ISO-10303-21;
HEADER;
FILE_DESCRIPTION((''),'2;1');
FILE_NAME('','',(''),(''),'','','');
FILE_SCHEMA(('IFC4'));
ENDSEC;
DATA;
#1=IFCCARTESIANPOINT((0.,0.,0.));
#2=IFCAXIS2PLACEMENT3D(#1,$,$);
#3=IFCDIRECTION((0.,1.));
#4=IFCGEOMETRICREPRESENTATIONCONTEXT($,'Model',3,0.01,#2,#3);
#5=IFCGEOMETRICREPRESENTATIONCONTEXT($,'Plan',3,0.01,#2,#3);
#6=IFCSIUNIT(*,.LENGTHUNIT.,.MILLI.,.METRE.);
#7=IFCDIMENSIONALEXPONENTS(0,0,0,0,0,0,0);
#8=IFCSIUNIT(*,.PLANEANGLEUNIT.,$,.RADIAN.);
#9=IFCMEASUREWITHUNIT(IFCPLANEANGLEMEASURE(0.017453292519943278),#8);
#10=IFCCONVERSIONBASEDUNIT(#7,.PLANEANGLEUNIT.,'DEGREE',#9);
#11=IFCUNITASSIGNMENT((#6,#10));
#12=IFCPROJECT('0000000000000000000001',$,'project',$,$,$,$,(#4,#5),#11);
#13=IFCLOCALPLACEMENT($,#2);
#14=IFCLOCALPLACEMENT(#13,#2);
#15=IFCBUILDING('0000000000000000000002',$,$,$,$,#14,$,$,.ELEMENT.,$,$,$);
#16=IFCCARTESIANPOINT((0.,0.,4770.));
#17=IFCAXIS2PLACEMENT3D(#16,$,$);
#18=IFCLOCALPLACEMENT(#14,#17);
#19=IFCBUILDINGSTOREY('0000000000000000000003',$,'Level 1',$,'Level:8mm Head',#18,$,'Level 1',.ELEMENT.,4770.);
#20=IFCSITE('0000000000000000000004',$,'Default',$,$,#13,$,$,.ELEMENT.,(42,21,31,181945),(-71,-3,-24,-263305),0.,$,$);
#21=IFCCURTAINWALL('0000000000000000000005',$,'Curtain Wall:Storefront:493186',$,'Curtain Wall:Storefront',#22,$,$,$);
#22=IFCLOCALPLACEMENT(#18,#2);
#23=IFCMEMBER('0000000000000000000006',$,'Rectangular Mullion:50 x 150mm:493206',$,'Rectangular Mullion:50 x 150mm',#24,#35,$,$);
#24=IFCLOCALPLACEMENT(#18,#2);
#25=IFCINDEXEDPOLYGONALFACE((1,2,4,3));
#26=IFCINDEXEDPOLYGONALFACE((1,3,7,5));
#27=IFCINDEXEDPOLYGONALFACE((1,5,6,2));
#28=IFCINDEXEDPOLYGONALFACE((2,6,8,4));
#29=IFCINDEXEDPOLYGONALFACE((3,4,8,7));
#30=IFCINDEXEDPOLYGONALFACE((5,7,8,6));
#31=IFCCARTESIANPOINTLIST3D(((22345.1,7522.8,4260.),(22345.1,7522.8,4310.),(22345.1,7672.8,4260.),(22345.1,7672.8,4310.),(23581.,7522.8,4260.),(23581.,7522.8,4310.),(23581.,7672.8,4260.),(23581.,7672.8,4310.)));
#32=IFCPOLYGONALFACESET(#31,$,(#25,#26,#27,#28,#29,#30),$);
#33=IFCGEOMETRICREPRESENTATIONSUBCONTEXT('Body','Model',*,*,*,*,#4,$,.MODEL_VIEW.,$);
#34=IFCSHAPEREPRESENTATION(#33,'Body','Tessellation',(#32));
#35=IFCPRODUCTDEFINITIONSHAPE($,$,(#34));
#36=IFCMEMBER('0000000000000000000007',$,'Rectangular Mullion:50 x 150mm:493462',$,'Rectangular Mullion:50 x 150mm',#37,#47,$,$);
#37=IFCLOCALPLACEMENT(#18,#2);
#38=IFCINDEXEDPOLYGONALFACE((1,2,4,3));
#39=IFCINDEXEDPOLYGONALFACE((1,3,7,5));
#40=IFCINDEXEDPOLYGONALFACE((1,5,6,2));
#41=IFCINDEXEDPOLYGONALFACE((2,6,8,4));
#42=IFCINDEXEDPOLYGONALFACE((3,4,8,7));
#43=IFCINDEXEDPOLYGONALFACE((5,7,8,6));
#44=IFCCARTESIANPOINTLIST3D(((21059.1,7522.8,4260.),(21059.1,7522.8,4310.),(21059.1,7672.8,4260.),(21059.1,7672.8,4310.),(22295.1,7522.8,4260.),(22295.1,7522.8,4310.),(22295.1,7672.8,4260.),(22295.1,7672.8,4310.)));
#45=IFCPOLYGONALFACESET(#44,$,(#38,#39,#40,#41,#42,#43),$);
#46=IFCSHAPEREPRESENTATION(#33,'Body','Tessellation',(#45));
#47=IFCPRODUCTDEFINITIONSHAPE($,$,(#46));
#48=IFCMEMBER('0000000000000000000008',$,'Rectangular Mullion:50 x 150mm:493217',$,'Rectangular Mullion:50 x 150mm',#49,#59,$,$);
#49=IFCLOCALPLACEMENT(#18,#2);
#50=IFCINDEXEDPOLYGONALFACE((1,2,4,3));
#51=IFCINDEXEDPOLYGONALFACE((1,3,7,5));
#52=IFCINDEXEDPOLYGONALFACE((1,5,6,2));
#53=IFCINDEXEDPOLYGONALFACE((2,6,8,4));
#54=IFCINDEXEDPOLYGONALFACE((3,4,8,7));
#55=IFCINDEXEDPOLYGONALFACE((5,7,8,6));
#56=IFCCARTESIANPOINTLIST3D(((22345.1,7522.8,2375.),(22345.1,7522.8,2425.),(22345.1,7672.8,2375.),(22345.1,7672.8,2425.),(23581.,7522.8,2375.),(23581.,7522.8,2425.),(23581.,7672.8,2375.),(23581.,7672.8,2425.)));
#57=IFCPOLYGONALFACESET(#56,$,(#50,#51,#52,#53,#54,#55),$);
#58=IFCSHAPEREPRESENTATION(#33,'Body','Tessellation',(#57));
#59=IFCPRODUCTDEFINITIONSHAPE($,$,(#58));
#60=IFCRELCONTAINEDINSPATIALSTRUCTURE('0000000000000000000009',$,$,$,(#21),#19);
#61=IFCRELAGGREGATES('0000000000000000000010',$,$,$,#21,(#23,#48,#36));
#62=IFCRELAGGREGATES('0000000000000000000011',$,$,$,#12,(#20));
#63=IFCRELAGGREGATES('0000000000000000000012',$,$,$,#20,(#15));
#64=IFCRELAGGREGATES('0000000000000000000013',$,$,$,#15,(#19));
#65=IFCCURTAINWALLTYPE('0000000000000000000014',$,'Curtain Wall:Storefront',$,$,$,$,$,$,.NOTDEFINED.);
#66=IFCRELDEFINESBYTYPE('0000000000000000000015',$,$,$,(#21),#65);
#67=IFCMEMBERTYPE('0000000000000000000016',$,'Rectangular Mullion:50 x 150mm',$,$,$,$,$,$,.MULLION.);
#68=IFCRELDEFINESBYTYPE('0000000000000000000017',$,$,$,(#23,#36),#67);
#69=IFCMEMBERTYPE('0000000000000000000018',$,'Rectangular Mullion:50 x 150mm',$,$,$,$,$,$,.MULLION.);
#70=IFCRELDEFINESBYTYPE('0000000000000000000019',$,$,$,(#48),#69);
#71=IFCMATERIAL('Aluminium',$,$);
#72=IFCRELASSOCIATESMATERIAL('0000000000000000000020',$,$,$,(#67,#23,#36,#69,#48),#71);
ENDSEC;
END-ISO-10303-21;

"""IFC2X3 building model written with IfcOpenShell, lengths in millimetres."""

from ifc_helpers import new_model, entity, si_unit, converted_unit, direction, frame, origin, origin_2d_with_axis, place, context, subcontext, project, spatial, rectangle, extrude, source, transform, mapped, material, type_object, type_shapes, element, aggregate, save


model = new_model("IFC2X3")

# Units and contexts
model_context = context("Model", 3, precision=0.01, world=origin(), true_north=direction((0.0, 1.0)))
plan_context = context("Plan", 3, precision=0.01, world=origin(), true_north=direction((0.0, 1.0)))
body_context = subcontext(model_context, "Body", "Model", "MODEL_VIEW")
ifc_project = project(units=[si_unit("LENGTHUNIT", "METRE", prefix="MILLI"), converted_unit("PLANEANGLEUNIT", "DEGREE", entity("IfcPlaneAngleMeasure", 0.017453292519943278), si_unit("PLANEANGLEUNIT", "RADIAN"), dimensions=[0, 0, 0, 0, 0, 0, 0])], contexts=[model_context, plan_context])

# Site, building, storey
site_placement = place(None, origin())
site = spatial("IfcSite", under=ifc_project, at=site_placement, Name="Default", CompositionType="ELEMENT", RefLatitude=(42, 21, 31, 181945), RefLongitude=(-71, -3, -24, -263305), RefElevation=0.0)
building_placement = place(site_placement, origin())
building = spatial("IfcBuilding", under=site, at=building_placement, CompositionType="ELEMENT")
storey_placement = place(building_placement, frame((0.0, 0.0, 4770.0)))
storey = spatial("IfcBuildingStorey", under=building, at=storey_placement, Name="Level 1", ObjectType="Level:8mm Head", LongName="Level 1", CompositionType="ELEMENT", Elevation=4770.0)

# Shared definitions
curtain_wall_type = type_object("IfcCurtainWallType", Name="Curtain Wall:Storefront", PredefinedType="NOTDEFINED")
ifc_material_1 = material(Name="Aluminium")

# Curtain wall
curtain_wall_1_placement = place(storey_placement, frame((0.0, 0.0, -4770.0)))
curtain_wall_1 = element("IfcCurtainWall", 1, at=curtain_wall_1_placement, inside=storey, type_object=curtain_wall_type, Name="Curtain Wall:Storefront:493186", ObjectType="Curtain Wall:Storefront")

# Members
member_type_1 = type_object("IfcMemberType", Name="Rectangular Mullion:50 x 150mm", PredefinedType="MULLION", material=ifc_material_1)
shared_shape_1 = source(origin(), body_context, "Body", "SweptSolid", [
    extrude(rectangle(XDim=50.0, YDim=150.0, at=origin_2d_with_axis()), frame((-25.0, 0.0, -1236.0), z_axis=(0.0, 0.0, 1.0), x_axis=(-1.0, 0.0, 0.0)), (0.0, 0.0, 1.0), 1236.0),
])
type_shapes(member_type_1, [shared_shape_1])
member_1_placement = place(curtain_wall_1_placement, frame((22345.1, 7597.8, 9080.0), z_axis=(-1.0, 0.0, 0.0), x_axis=(0.0, 0.0, 1.0)))
member_1 = element("IfcMember", 2, at=member_1_placement, type_object=member_type_1, material=ifc_material_1, Name="Rectangular Mullion:50 x 150mm:493206", ObjectType="Rectangular Mullion:50 x 150mm", context=body_context, shape_type="MappedRepresentation", body=[
    mapped(shared_shape_1, transform((0.0, 0.0, 0.0), scale=1.0)),
])
member_2_placement = place(curtain_wall_1_placement, frame((21059.1, 7597.8, 9080.0), z_axis=(-1.0, 0.0, 0.0), x_axis=(0.0, 0.0, 1.0)))
member_2 = element("IfcMember", 3, at=member_2_placement, type_object=member_type_1, material=ifc_material_1, Name="Rectangular Mullion:50 x 150mm:493462", ObjectType="Rectangular Mullion:50 x 150mm", context=body_context, shape_type="MappedRepresentation", body=[
    mapped(shared_shape_1, transform((0.0, 0.0, 0.0), scale=1.0)),
])
member_type_2 = type_object("IfcMemberType", Name="Rectangular Mullion:50 x 150mm", PredefinedType="MULLION", material=ifc_material_1)
shared_shape_2 = source(origin(), body_context, "Body", "SweptSolid", [
    extrude(rectangle(XDim=50.0, YDim=150.0, at=origin_2d_with_axis()), frame((0.0, 0.0, -1236.0), z_axis=(0.0, 0.0, 1.0), x_axis=(-1.0, 0.0, 0.0)), (0.0, 0.0, 1.0), 1236.0),
])
type_shapes(member_type_2, [shared_shape_2])
member_3_placement = place(curtain_wall_1_placement, frame((22345.1, 7597.8, 7170.0), z_axis=(-1.0, 0.0, 0.0), x_axis=(0.0, 0.0, 1.0)))
member_3 = element("IfcMember", 4, at=member_3_placement, type_object=member_type_2, material=ifc_material_1, Name="Rectangular Mullion:50 x 150mm:493217", ObjectType="Rectangular Mullion:50 x 150mm", context=body_context, shape_type="MappedRepresentation", body=[
    mapped(shared_shape_2, transform((0.0, 0.0, 0.0), scale=1.0)),
])

aggregate(curtain_wall_1, [member_1, member_3, member_2])

save(model, "model.ifc")
